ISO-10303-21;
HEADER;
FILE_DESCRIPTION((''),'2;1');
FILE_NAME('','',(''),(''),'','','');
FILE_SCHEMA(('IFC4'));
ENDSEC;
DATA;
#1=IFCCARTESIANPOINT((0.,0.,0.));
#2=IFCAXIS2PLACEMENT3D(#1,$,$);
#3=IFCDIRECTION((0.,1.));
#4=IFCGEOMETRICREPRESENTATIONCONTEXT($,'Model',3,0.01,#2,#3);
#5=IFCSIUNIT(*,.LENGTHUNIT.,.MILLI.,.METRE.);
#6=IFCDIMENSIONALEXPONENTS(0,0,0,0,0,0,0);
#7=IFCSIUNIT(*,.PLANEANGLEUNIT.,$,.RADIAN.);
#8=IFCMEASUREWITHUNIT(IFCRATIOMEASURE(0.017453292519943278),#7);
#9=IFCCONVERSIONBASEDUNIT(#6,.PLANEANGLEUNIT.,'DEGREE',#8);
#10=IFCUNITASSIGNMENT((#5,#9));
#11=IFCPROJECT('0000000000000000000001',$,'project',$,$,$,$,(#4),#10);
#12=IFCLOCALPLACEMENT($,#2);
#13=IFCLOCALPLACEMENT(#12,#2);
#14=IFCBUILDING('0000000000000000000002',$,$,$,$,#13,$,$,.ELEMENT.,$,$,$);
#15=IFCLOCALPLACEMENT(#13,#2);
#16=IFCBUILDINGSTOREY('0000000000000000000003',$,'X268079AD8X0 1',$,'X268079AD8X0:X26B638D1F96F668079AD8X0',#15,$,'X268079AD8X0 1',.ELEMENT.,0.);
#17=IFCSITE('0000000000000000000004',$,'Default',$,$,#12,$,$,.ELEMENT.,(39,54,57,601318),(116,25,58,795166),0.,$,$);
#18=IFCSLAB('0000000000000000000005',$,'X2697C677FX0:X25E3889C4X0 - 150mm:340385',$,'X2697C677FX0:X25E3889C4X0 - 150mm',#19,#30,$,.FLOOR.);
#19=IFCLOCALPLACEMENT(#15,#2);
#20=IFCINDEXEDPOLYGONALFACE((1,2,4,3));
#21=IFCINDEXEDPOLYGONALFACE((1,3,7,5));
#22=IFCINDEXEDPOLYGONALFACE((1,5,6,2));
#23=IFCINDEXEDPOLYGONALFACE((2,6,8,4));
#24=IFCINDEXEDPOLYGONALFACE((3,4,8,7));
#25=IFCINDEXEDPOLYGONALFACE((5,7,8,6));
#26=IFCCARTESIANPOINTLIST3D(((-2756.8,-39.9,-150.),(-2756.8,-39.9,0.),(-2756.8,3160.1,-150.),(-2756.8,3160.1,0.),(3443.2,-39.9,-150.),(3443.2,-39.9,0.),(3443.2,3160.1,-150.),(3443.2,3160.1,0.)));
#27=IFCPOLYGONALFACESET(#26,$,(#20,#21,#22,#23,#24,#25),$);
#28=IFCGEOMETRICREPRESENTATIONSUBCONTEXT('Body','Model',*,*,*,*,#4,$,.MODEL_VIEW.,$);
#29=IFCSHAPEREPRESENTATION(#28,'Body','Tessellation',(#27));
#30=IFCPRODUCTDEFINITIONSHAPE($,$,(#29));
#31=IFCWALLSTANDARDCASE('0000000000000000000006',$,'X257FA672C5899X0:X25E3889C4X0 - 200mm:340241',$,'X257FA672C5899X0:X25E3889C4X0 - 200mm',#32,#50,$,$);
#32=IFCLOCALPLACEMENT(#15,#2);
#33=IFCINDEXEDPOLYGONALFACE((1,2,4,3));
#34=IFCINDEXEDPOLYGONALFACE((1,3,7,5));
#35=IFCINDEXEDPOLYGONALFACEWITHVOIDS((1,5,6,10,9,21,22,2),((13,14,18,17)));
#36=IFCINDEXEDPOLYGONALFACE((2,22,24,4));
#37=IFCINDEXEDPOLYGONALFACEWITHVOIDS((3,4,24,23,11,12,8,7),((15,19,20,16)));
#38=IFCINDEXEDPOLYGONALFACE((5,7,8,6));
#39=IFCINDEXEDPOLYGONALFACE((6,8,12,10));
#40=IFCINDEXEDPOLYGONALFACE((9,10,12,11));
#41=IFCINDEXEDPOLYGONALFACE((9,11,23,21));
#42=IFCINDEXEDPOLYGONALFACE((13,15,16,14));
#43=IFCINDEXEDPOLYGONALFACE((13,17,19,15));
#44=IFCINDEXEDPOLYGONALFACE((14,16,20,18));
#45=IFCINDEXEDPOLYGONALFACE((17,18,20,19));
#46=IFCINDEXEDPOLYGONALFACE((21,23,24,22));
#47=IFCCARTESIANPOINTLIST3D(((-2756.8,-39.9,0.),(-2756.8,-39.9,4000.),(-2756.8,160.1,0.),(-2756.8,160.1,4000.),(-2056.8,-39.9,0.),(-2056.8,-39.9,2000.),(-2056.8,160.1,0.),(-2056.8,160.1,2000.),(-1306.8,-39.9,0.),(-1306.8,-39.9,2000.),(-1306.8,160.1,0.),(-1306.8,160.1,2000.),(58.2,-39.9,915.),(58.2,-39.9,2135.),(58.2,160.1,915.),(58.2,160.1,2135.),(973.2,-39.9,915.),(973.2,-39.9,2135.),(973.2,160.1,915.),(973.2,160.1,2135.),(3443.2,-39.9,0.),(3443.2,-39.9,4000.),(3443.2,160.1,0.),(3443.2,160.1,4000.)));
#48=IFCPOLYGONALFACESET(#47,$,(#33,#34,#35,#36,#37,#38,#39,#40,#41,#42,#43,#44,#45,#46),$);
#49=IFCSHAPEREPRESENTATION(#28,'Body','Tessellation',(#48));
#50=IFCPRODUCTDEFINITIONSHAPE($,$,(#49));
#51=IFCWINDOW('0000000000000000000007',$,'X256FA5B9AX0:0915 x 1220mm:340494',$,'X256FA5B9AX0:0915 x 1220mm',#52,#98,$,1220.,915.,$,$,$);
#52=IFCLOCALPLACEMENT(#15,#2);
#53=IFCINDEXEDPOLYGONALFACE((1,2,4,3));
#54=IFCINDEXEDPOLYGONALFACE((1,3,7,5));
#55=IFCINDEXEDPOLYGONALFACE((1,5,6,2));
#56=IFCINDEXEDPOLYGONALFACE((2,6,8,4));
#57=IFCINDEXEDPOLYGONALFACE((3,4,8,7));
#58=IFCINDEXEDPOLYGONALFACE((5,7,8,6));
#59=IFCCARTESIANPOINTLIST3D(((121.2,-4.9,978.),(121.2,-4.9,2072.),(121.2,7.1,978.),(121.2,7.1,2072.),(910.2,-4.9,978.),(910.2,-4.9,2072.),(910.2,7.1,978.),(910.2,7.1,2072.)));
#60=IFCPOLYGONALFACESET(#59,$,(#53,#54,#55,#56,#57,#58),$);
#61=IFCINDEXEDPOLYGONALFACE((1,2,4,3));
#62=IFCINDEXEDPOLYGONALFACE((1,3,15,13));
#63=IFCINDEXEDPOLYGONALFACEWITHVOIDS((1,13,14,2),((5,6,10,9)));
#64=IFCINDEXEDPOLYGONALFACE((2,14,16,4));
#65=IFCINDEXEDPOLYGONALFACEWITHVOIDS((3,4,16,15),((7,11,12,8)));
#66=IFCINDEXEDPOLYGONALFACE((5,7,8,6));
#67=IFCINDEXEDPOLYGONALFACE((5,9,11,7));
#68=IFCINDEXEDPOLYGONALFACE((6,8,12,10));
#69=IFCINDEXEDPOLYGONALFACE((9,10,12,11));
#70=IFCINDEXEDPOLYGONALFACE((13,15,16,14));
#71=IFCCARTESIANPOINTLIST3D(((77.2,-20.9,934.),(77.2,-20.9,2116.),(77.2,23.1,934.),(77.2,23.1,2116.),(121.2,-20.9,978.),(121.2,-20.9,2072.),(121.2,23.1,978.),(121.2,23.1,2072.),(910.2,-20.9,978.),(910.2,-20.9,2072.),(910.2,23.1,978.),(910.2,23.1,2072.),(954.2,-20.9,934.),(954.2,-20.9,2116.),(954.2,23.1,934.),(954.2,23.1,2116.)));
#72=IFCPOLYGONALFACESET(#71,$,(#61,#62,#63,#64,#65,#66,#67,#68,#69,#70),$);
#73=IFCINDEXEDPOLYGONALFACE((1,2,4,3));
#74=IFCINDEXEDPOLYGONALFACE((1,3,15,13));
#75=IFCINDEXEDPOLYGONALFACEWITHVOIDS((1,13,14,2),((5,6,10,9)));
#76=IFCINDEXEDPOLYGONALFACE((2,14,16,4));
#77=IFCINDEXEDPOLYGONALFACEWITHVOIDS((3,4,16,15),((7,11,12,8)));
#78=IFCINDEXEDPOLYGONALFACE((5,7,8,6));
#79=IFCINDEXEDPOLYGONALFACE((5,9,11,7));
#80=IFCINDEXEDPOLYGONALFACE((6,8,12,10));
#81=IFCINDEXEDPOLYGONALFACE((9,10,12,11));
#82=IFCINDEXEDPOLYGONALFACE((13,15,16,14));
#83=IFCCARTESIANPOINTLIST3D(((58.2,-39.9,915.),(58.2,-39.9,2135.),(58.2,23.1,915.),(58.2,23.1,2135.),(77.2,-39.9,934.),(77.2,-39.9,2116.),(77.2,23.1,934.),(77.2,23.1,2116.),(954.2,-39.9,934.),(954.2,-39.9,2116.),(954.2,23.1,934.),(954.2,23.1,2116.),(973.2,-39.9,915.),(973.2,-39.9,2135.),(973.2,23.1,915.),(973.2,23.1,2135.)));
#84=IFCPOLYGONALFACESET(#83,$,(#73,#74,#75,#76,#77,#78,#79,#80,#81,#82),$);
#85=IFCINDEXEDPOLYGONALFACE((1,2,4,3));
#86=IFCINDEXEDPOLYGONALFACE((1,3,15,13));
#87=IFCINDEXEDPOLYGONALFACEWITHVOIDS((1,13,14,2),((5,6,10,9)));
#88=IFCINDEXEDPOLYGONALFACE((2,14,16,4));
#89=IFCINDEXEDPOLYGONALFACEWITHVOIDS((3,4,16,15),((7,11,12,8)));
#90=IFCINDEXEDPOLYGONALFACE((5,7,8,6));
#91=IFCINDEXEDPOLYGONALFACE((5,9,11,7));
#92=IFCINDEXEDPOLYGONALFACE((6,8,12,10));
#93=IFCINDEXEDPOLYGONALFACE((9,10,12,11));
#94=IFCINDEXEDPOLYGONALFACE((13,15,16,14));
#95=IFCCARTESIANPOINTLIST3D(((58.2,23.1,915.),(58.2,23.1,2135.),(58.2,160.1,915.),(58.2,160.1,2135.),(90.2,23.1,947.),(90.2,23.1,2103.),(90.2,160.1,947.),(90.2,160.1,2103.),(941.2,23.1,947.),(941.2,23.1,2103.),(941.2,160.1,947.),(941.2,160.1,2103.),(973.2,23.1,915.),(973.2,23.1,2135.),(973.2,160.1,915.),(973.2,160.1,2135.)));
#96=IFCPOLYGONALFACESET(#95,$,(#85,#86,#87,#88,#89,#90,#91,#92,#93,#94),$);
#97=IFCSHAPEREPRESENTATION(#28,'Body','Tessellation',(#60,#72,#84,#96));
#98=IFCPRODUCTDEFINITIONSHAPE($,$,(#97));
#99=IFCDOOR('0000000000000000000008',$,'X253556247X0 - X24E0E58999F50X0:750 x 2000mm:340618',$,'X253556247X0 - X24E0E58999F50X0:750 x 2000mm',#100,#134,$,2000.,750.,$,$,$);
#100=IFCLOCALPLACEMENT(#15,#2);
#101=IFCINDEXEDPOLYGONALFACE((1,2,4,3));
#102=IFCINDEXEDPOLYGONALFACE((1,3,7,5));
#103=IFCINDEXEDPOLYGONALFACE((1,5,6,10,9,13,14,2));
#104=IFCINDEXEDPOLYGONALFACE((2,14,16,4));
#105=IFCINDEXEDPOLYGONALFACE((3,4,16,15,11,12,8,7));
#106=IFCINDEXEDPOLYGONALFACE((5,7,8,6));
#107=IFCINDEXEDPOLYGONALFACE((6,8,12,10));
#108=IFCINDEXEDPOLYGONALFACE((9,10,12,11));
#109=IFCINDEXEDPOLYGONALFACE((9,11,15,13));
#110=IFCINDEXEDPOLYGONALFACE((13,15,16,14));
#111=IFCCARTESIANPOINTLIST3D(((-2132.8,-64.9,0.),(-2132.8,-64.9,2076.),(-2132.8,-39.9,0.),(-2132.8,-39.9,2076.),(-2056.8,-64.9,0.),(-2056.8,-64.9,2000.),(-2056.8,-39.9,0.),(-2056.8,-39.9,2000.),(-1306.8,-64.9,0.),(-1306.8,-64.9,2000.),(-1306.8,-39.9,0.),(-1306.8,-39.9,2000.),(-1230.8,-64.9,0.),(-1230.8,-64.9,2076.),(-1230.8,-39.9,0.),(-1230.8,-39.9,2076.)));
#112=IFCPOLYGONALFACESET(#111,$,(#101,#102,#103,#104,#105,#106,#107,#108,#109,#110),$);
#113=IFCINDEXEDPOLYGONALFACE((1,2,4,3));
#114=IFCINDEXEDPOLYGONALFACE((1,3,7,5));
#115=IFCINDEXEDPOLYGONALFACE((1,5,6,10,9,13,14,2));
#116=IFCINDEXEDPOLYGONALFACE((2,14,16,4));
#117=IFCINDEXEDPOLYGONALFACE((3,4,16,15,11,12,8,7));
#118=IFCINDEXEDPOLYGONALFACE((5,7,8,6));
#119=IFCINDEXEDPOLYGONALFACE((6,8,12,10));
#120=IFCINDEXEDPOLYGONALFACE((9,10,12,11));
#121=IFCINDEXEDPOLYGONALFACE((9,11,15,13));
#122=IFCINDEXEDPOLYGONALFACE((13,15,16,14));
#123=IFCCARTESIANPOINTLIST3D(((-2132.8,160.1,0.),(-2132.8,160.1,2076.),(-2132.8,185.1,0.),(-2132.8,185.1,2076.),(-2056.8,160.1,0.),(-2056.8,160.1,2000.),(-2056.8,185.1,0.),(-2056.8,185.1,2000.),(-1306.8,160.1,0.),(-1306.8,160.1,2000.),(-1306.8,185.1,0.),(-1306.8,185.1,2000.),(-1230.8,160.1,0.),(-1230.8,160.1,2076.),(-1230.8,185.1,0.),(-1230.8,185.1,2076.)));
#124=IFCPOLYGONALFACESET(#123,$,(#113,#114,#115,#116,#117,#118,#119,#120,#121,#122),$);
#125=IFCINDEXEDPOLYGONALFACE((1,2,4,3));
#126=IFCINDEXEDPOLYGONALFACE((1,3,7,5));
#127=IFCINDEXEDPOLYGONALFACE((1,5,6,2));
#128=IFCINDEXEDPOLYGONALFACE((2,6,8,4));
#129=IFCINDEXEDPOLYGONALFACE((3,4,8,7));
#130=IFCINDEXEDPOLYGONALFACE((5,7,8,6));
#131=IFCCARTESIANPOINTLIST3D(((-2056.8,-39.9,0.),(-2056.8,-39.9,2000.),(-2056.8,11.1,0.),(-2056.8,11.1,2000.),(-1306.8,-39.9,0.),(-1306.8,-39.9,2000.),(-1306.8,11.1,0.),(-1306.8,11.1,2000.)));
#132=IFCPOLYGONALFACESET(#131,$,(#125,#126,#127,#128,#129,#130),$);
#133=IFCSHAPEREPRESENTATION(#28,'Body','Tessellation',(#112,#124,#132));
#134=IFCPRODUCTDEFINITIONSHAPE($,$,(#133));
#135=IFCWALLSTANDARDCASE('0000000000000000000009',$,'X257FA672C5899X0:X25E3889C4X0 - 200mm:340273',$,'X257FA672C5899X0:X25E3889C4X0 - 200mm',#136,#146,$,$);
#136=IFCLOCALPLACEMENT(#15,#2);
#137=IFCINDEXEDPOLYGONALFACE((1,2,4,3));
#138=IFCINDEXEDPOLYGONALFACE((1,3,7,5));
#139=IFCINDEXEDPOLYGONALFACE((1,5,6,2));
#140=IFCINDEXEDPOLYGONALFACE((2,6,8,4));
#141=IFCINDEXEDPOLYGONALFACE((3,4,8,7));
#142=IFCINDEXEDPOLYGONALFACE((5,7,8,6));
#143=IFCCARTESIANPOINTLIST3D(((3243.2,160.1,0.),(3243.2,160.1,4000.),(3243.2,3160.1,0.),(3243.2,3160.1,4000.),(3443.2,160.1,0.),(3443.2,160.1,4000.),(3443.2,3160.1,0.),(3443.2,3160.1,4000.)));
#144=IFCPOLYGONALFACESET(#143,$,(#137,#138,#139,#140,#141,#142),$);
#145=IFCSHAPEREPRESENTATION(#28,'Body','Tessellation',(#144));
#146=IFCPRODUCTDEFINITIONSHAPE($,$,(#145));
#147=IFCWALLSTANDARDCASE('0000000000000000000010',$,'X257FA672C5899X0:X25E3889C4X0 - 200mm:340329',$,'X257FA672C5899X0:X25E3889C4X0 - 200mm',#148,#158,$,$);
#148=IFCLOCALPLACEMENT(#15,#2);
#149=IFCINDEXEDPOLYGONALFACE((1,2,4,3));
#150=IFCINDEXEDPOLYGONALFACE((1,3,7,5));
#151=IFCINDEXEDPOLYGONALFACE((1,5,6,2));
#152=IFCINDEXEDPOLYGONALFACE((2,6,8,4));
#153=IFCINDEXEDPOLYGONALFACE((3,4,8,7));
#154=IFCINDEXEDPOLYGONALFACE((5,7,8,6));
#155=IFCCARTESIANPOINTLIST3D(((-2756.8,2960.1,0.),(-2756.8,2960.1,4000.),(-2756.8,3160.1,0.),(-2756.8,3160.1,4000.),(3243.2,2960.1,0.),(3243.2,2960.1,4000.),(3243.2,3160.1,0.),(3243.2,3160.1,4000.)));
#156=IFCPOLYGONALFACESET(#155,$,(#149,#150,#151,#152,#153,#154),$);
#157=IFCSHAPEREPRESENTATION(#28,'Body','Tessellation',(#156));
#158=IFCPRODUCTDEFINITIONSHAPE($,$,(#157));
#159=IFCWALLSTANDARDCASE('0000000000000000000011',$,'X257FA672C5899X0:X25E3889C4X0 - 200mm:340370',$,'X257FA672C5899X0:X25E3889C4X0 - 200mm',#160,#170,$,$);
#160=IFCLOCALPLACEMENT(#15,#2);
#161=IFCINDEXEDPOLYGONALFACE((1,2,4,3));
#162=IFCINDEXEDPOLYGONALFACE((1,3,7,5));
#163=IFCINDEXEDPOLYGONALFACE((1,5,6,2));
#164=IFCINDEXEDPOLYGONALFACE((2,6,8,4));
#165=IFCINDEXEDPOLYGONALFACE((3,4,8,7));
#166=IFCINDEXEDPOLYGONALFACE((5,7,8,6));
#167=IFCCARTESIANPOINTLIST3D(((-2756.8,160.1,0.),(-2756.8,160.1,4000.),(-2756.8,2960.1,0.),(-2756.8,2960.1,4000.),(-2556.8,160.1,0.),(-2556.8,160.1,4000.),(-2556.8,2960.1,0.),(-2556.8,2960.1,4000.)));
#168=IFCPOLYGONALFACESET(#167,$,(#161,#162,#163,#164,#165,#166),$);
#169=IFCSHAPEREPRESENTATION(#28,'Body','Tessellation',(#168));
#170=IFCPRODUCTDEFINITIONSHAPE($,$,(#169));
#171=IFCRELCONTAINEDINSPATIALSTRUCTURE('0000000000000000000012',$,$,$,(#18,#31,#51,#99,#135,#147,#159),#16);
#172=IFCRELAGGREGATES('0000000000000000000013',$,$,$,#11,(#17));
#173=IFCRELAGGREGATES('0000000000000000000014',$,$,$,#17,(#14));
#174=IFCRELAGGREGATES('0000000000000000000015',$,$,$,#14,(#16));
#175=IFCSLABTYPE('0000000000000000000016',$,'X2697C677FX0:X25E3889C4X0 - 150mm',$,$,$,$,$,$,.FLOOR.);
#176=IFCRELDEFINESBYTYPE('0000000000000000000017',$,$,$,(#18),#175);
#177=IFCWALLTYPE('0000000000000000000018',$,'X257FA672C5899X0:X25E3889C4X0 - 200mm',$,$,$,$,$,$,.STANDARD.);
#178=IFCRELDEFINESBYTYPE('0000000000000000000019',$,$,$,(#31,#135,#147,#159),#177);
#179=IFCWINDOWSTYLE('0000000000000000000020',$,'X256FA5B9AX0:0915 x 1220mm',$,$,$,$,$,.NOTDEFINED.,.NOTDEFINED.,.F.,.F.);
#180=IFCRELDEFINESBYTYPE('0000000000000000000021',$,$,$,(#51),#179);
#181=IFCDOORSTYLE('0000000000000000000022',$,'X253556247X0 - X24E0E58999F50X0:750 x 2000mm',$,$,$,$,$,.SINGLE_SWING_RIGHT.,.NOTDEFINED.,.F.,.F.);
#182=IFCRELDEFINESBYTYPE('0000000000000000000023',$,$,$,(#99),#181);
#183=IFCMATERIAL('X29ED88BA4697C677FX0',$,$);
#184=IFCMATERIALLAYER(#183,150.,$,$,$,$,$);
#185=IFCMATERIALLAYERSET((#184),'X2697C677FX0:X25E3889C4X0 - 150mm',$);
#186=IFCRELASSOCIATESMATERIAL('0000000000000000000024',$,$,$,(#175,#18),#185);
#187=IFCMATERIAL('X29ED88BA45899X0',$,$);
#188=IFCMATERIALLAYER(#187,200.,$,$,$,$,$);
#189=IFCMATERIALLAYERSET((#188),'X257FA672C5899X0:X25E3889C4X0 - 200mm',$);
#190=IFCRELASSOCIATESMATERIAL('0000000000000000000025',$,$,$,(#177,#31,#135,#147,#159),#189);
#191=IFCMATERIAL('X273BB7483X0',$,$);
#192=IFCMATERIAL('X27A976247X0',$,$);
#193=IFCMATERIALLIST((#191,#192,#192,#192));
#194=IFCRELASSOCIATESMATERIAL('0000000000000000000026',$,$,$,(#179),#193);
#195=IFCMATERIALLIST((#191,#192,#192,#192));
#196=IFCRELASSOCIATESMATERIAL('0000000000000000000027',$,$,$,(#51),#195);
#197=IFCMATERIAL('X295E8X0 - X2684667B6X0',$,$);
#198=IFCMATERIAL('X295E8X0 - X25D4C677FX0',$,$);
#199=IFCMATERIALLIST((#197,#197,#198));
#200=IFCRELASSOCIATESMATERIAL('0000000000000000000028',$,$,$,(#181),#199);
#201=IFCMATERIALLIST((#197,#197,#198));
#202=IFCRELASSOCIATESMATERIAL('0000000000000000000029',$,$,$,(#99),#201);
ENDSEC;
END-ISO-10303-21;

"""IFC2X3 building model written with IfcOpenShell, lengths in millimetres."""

from ifc_helpers import new_model, entity, si_unit, converted_unit, direction, frame, frame_2d, origin, place, context, subcontext, project, spatial, polyline, rectangle, outline, extrude, source, transform, mapped, material, material_list, layer, layer_set, layer_usage, type_object, type_shapes, element, fill, save


model = new_model("IFC2X3")

# Units and contexts
model_context = context("Model", 3, precision=0.01, world=origin(), true_north=direction((0.0, 1.0)))
body_context = subcontext(model_context, "Body", "Model", "MODEL_VIEW")
ifc_project = project(units=[si_unit("LENGTHUNIT", "METRE", prefix="MILLI"), converted_unit("PLANEANGLEUNIT", "DEGREE", entity("IfcRatioMeasure", 0.017453292519943278), si_unit("PLANEANGLEUNIT", "RADIAN"), dimensions=[0, 0, 0, 0, 0, 0, 0])], contexts=[model_context])

# Site, building, storey
site_placement = place(None, origin())
site = spatial("IfcSite", under=ifc_project, at=site_placement, Name="Default", CompositionType="ELEMENT", RefLatitude=(39, 54, 57, 601318), RefLongitude=(116, 25, 58, 795166), RefElevation=0.0)
building_placement = place(site_placement, origin())
building = spatial("IfcBuilding", under=site, at=building_placement, CompositionType="ELEMENT")
storey_placement = place(building_placement, origin())
storey = spatial("IfcBuildingStorey", under=building, at=storey_placement, Name="X268079AD8X0 1", ObjectType="X268079AD8X0:X26B638D1F96F668079AD8X0", LongName="X268079AD8X0 1", CompositionType="ELEMENT", Elevation=0.0)

# Slab
ifc_material_1 = material(Name="X29ED88BA4697C677FX0")
ifc_layer_1 = layer(ifc_material_1, 150.0)
ifc_layer_set_1 = layer_set([ifc_layer_1], Name="X2697C677FX0:X25E3889C4X0 - 150mm")
ifc_layer_usage_1 = layer_usage(ifc_layer_set_1, "AXIS3", "POSITIVE", 0.0)
slab_type = type_object("IfcSlabType", Name="X2697C677FX0:X25E3889C4X0 - 150mm", PredefinedType="FLOOR", material=ifc_layer_set_1)
slab_placement = place(storey_placement, origin())
element("IfcSlab", 1, at=slab_placement, inside=storey, type_object=slab_type, material=ifc_layer_usage_1, Name="X2697C677FX0:X25E3889C4X0 - 150mm:340385", ObjectType="X2697C677FX0:X25E3889C4X0 - 150mm", PredefinedType="FLOOR", context=body_context, shape_type="SweptSolid", body=[
    extrude(rectangle(XDim=3200.0, YDim=6200.0, at=frame_2d((0.0, 0.0), x_axis=(1.0, 0.0))), frame((343.2, 1560.1, 0.0), z_axis=(0.0, 0.0, -1.0), x_axis=(0.0, 1.0, 0.0)), (0.0, 0.0, 1.0), 150.0),
])

# Wall, openings, window, door
ifc_material_2 = material(Name="X29ED88BA45899X0")
ifc_layer_2 = layer(ifc_material_2, 200.0)
ifc_layer_set_2 = layer_set([ifc_layer_2], Name="X257FA672C5899X0:X25E3889C4X0 - 200mm")
ifc_layer_usage_2 = layer_usage(ifc_layer_set_2, "AXIS2", "NEGATIVE", 100.0)
wall_type = type_object("IfcWallType", Name="X257FA672C5899X0:X25E3889C4X0 - 200mm", PredefinedType="STANDARD", material=ifc_layer_set_2)
wall_1_placement = place(storey_placement, frame((-2756.8, 60.1, 0.0)))
wall_1 = element("IfcWallStandardCase", 2, at=wall_1_placement, inside=storey, type_object=wall_type, material=ifc_layer_usage_2, Name="X257FA672C5899X0:X25E3889C4X0 - 200mm:340241", ObjectType="X257FA672C5899X0:X25E3889C4X0 - 200mm", context=body_context, shape_type="SweptSolid", body=[
    extrude(rectangle(XDim=6200.0, YDim=200.0, at=frame_2d((3100.0, 0.0), x_axis=(1.0, 0.0))), origin(), (0.0, 0.0, 1.0), 4000.0),
])
opening_1_placement = place(wall_1_placement, frame((1450.0, 100.0, 0.0)))
opening_1 = element("IfcOpeningElement", 3, at=opening_1_placement, cuts=wall_1, ObjectType="Opening", context=body_context, shape_type="SweptSolid", body=[
    extrude(rectangle(XDim=750.0, YDim=2000.0, at=frame_2d((1000.0, 375.0), x_axis=(0.0, 1.0))), frame((0.0, 0.0, 0.0), z_axis=(0.0, -1.0, 0.0), x_axis=(0.0, 0.0, 1.0)), (0.0, 0.0, 1.0), 200.0),
])
opening_2_placement = place(wall_1_placement, frame((3730.0, 100.0, 915.0)))
opening_2 = element("IfcOpeningElement", 4, at=opening_2_placement, cuts=wall_1, ObjectType="Opening", context=body_context, shape_type="SweptSolid", body=[
    extrude(rectangle(XDim=1220.0, YDim=915.0, at=frame_2d((610.0, 457.5), x_axis=(1.0, 0.0))), frame((0.0, 0.0, 0.0), z_axis=(0.0, -1.0, 0.0), x_axis=(0.0, 0.0, 1.0)), (0.0, 0.0, 1.0), 200.0),
])
ifc_material_3 = material(Name="X273BB7483X0")
ifc_material_4 = material(Name="X27A976247X0")
ifc_material_list_1 = material_list([ifc_material_3, ifc_material_4, ifc_material_4, ifc_material_4])
ifc_material_list_2 = material_list([ifc_material_3, ifc_material_4, ifc_material_4, ifc_material_4])
window_style = type_object("IfcWindowStyle", Name="X256FA5B9AX0:0915 x 1220mm", ConstructionType="NOTDEFINED", OperationType="NOTDEFINED", ParameterTakesPrecedence=False, Sizeable=False, material=ifc_material_list_2)
shared_shape_1 = source(origin(), body_context, "Body", "SweptSolid", [
    extrude(rectangle(XDim=12.0, YDim=789.0, at=frame_2d((0.0, 0.0), x_axis=(1.0, 0.0))), frame((457.5, 159.0, 63.0), z_axis=(0.0, 0.0, 1.0), x_axis=(0.0, -1.0, 0.0)), (0.0, 0.0, 1.0), 1094.0),
    extrude(outline(polyline([(-438.5, -591.0), (438.5, -591.0), (438.5, 591.0), (-438.5, 591.0), (-438.5, -591.0)]), holes=[polyline([(-394.5, -547.0), (-394.5, 547.0), (394.5, 547.0), (394.5, -547.0), (-394.5, -547.0)])]), frame((457.5, 137.0, 610.0), z_axis=(0.0, 1.0, 0.0), x_axis=(1.0, 0.0, 0.0)), (0.0, 0.0, 1.0), 44.0),
    extrude(outline(polyline([(-457.5, -610.0), (457.5, -610.0), (457.5, 610.0), (-457.5, 610.0), (-457.5, -610.0)]), holes=[polyline([(-438.5, -591.0), (-438.5, 591.0), (438.5, 591.0), (438.5, -591.0), (-438.5, -591.0)])]), frame((457.5, 137.0, 610.0), z_axis=(0.0, 1.0, 0.0), x_axis=(1.0, 0.0, 0.0)), (0.0, 0.0, 1.0), 63.0),
    extrude(outline(polyline([(-457.5, -610.0), (457.5, -610.0), (457.5, 610.0), (-457.5, 610.0), (-457.5, -610.0)]), holes=[polyline([(-425.5, -578.0), (-425.5, 578.0), (425.5, 578.0), (425.5, -578.0), (-425.5, -578.0)])]), frame((457.5, 0.0, 610.0), z_axis=(0.0, 1.0, 0.0), x_axis=(1.0, 0.0, 0.0)), (0.0, 0.0, 1.0), 137.0),
])
type_shapes(window_style, [shared_shape_1])
window_placement = place(opening_2_placement, frame((0.0, 0.0, 0.0), z_axis=(0.0, 0.0, 1.0), x_axis=(-1.0, 0.0, 0.0)))
window = element("IfcWindow", 5, at=window_placement, inside=storey, type_object=window_style, material=ifc_material_list_1, Name="X256FA5B9AX0:0915 x 1220mm:340494", ObjectType="X256FA5B9AX0:0915 x 1220mm", OverallHeight=1220.0, OverallWidth=915.0, context=body_context, shape_type="MappedRepresentation", body=[
    mapped(shared_shape_1, transform((0.0, 0.0, 0.0), scale=1.0)),
])
fill(opening_2, window)
ifc_material_5 = material(Name="X295E8X0 - X2684667B6X0")
ifc_material_6 = material(Name="X295E8X0 - X25D4C677FX0")
ifc_material_list_3 = material_list([ifc_material_5, ifc_material_5, ifc_material_6])
ifc_material_list_4 = material_list([ifc_material_5, ifc_material_5, ifc_material_6])
door_style = type_object("IfcDoorStyle", Name="X253556247X0 - X24E0E58999F50X0:750 x 2000mm", ConstructionType="NOTDEFINED", OperationType="SINGLE_SWING_RIGHT", ParameterTakesPrecedence=False, Sizeable=False, material=ifc_material_list_4)
shared_shape_2 = source(origin(), body_context, "Body", "SweptSolid", [
    extrude(outline(polyline([(-451.0, -1057.0), (451.0, -1057.0), (451.0, 1019.0), (375.0, 1019.0), (375.0, -981.0), (-375.0, -981.0), (-375.0, 1019.0), (-451.0, 1019.0), (-451.0, -1057.0)])), frame((375.0, 200.0, 1019.0), z_axis=(0.0, 1.0, 0.0), x_axis=(1.0, 0.0, 0.0)), (0.0, 0.0, 1.0), 25.0),
    extrude(outline(polyline([(-1057.0, -451.0), (1019.0, -451.0), (1019.0, -375.0), (-981.0, -375.0), (-981.0, 375.0), (1019.0, 375.0), (1019.0, 451.0), (-1057.0, 451.0), (-1057.0, -451.0)])), frame((375.0, -25.0, 1019.0), z_axis=(0.0, 1.0, 0.0), x_axis=(0.0, 0.0, -1.0)), (0.0, 0.0, 1.0), 25.0),
    extrude(rectangle(XDim=51.0, YDim=750.0, at=frame_2d((0.0, 0.0), x_axis=(1.0, 0.0))), frame((375.0, 174.5, 0.0), z_axis=(0.0, 0.0, 1.0), x_axis=(0.0, 1.0, 0.0)), (0.0, 0.0, 1.0), 2000.0),
])
type_shapes(door_style, [shared_shape_2])
door_placement = place(opening_1_placement, frame((0.0, 0.0, 0.0), z_axis=(0.0, 0.0, 1.0), x_axis=(-1.0, 0.0, 0.0)))
door = element("IfcDoor", 6, at=door_placement, inside=storey, type_object=door_style, material=ifc_material_list_3, Name="X253556247X0 - X24E0E58999F50X0:750 x 2000mm:340618", ObjectType="X253556247X0 - X24E0E58999F50X0:750 x 2000mm", OverallHeight=2000.0, OverallWidth=750.0, context=body_context, shape_type="MappedRepresentation", body=[
    mapped(shared_shape_2, transform((0.0, 0.0, 0.0), scale=1.0)),
])
fill(opening_1, door)

# Walls
ifc_layer_usage_3 = layer_usage(ifc_layer_set_2, "AXIS2", "NEGATIVE", 100.0)
wall_2_placement = place(storey_placement, frame((3343.2, 160.1, 0.0), z_axis=(0.0, 0.0, 1.0), x_axis=(0.0, 1.0, 0.0)))
element("IfcWallStandardCase", 7, at=wall_2_placement, inside=storey, type_object=wall_type, material=ifc_layer_usage_3, Name="X257FA672C5899X0:X25E3889C4X0 - 200mm:340273", ObjectType="X257FA672C5899X0:X25E3889C4X0 - 200mm", context=body_context, shape_type="SweptSolid", body=[
    extrude(rectangle(XDim=3000.0, YDim=200.0, at=frame_2d((1500.0, 0.0), x_axis=(-1.0, 0.0))), origin(), (0.0, 0.0, 1.0), 4000.0),
])
ifc_layer_usage_4 = layer_usage(ifc_layer_set_2, "AXIS2", "NEGATIVE", 100.0)
wall_3_placement = place(storey_placement, frame((3243.2, 3060.1, 0.0), z_axis=(0.0, 0.0, 1.0), x_axis=(-1.0, 0.0, 0.0)))
element("IfcWallStandardCase", 8, at=wall_3_placement, inside=storey, type_object=wall_type, material=ifc_layer_usage_4, Name="X257FA672C5899X0:X25E3889C4X0 - 200mm:340329", ObjectType="X257FA672C5899X0:X25E3889C4X0 - 200mm", context=body_context, shape_type="SweptSolid", body=[
    extrude(rectangle(XDim=6000.0, YDim=200.0, at=frame_2d((3000.0, 0.0), x_axis=(-1.0, 0.0))), origin(), (0.0, 0.0, 1.0), 4000.0),
])
ifc_layer_usage_5 = layer_usage(ifc_layer_set_2, "AXIS2", "NEGATIVE", 100.0)
wall_4_placement = place(storey_placement, frame((-2656.8, 2960.1, 0.0), z_axis=(0.0, 0.0, 1.0), x_axis=(0.0, -1.0, 0.0)))
element("IfcWallStandardCase", 9, at=wall_4_placement, inside=storey, type_object=wall_type, material=ifc_layer_usage_5, Name="X257FA672C5899X0:X25E3889C4X0 - 200mm:340370", ObjectType="X257FA672C5899X0:X25E3889C4X0 - 200mm", context=body_context, shape_type="SweptSolid", body=[
    extrude(rectangle(XDim=2800.0, YDim=200.0, at=frame_2d((1400.0, 0.0), x_axis=(-1.0, 0.0))), origin(), (0.0, 0.0, 1.0), 4000.0),
])

save(model, "model.ifc")
